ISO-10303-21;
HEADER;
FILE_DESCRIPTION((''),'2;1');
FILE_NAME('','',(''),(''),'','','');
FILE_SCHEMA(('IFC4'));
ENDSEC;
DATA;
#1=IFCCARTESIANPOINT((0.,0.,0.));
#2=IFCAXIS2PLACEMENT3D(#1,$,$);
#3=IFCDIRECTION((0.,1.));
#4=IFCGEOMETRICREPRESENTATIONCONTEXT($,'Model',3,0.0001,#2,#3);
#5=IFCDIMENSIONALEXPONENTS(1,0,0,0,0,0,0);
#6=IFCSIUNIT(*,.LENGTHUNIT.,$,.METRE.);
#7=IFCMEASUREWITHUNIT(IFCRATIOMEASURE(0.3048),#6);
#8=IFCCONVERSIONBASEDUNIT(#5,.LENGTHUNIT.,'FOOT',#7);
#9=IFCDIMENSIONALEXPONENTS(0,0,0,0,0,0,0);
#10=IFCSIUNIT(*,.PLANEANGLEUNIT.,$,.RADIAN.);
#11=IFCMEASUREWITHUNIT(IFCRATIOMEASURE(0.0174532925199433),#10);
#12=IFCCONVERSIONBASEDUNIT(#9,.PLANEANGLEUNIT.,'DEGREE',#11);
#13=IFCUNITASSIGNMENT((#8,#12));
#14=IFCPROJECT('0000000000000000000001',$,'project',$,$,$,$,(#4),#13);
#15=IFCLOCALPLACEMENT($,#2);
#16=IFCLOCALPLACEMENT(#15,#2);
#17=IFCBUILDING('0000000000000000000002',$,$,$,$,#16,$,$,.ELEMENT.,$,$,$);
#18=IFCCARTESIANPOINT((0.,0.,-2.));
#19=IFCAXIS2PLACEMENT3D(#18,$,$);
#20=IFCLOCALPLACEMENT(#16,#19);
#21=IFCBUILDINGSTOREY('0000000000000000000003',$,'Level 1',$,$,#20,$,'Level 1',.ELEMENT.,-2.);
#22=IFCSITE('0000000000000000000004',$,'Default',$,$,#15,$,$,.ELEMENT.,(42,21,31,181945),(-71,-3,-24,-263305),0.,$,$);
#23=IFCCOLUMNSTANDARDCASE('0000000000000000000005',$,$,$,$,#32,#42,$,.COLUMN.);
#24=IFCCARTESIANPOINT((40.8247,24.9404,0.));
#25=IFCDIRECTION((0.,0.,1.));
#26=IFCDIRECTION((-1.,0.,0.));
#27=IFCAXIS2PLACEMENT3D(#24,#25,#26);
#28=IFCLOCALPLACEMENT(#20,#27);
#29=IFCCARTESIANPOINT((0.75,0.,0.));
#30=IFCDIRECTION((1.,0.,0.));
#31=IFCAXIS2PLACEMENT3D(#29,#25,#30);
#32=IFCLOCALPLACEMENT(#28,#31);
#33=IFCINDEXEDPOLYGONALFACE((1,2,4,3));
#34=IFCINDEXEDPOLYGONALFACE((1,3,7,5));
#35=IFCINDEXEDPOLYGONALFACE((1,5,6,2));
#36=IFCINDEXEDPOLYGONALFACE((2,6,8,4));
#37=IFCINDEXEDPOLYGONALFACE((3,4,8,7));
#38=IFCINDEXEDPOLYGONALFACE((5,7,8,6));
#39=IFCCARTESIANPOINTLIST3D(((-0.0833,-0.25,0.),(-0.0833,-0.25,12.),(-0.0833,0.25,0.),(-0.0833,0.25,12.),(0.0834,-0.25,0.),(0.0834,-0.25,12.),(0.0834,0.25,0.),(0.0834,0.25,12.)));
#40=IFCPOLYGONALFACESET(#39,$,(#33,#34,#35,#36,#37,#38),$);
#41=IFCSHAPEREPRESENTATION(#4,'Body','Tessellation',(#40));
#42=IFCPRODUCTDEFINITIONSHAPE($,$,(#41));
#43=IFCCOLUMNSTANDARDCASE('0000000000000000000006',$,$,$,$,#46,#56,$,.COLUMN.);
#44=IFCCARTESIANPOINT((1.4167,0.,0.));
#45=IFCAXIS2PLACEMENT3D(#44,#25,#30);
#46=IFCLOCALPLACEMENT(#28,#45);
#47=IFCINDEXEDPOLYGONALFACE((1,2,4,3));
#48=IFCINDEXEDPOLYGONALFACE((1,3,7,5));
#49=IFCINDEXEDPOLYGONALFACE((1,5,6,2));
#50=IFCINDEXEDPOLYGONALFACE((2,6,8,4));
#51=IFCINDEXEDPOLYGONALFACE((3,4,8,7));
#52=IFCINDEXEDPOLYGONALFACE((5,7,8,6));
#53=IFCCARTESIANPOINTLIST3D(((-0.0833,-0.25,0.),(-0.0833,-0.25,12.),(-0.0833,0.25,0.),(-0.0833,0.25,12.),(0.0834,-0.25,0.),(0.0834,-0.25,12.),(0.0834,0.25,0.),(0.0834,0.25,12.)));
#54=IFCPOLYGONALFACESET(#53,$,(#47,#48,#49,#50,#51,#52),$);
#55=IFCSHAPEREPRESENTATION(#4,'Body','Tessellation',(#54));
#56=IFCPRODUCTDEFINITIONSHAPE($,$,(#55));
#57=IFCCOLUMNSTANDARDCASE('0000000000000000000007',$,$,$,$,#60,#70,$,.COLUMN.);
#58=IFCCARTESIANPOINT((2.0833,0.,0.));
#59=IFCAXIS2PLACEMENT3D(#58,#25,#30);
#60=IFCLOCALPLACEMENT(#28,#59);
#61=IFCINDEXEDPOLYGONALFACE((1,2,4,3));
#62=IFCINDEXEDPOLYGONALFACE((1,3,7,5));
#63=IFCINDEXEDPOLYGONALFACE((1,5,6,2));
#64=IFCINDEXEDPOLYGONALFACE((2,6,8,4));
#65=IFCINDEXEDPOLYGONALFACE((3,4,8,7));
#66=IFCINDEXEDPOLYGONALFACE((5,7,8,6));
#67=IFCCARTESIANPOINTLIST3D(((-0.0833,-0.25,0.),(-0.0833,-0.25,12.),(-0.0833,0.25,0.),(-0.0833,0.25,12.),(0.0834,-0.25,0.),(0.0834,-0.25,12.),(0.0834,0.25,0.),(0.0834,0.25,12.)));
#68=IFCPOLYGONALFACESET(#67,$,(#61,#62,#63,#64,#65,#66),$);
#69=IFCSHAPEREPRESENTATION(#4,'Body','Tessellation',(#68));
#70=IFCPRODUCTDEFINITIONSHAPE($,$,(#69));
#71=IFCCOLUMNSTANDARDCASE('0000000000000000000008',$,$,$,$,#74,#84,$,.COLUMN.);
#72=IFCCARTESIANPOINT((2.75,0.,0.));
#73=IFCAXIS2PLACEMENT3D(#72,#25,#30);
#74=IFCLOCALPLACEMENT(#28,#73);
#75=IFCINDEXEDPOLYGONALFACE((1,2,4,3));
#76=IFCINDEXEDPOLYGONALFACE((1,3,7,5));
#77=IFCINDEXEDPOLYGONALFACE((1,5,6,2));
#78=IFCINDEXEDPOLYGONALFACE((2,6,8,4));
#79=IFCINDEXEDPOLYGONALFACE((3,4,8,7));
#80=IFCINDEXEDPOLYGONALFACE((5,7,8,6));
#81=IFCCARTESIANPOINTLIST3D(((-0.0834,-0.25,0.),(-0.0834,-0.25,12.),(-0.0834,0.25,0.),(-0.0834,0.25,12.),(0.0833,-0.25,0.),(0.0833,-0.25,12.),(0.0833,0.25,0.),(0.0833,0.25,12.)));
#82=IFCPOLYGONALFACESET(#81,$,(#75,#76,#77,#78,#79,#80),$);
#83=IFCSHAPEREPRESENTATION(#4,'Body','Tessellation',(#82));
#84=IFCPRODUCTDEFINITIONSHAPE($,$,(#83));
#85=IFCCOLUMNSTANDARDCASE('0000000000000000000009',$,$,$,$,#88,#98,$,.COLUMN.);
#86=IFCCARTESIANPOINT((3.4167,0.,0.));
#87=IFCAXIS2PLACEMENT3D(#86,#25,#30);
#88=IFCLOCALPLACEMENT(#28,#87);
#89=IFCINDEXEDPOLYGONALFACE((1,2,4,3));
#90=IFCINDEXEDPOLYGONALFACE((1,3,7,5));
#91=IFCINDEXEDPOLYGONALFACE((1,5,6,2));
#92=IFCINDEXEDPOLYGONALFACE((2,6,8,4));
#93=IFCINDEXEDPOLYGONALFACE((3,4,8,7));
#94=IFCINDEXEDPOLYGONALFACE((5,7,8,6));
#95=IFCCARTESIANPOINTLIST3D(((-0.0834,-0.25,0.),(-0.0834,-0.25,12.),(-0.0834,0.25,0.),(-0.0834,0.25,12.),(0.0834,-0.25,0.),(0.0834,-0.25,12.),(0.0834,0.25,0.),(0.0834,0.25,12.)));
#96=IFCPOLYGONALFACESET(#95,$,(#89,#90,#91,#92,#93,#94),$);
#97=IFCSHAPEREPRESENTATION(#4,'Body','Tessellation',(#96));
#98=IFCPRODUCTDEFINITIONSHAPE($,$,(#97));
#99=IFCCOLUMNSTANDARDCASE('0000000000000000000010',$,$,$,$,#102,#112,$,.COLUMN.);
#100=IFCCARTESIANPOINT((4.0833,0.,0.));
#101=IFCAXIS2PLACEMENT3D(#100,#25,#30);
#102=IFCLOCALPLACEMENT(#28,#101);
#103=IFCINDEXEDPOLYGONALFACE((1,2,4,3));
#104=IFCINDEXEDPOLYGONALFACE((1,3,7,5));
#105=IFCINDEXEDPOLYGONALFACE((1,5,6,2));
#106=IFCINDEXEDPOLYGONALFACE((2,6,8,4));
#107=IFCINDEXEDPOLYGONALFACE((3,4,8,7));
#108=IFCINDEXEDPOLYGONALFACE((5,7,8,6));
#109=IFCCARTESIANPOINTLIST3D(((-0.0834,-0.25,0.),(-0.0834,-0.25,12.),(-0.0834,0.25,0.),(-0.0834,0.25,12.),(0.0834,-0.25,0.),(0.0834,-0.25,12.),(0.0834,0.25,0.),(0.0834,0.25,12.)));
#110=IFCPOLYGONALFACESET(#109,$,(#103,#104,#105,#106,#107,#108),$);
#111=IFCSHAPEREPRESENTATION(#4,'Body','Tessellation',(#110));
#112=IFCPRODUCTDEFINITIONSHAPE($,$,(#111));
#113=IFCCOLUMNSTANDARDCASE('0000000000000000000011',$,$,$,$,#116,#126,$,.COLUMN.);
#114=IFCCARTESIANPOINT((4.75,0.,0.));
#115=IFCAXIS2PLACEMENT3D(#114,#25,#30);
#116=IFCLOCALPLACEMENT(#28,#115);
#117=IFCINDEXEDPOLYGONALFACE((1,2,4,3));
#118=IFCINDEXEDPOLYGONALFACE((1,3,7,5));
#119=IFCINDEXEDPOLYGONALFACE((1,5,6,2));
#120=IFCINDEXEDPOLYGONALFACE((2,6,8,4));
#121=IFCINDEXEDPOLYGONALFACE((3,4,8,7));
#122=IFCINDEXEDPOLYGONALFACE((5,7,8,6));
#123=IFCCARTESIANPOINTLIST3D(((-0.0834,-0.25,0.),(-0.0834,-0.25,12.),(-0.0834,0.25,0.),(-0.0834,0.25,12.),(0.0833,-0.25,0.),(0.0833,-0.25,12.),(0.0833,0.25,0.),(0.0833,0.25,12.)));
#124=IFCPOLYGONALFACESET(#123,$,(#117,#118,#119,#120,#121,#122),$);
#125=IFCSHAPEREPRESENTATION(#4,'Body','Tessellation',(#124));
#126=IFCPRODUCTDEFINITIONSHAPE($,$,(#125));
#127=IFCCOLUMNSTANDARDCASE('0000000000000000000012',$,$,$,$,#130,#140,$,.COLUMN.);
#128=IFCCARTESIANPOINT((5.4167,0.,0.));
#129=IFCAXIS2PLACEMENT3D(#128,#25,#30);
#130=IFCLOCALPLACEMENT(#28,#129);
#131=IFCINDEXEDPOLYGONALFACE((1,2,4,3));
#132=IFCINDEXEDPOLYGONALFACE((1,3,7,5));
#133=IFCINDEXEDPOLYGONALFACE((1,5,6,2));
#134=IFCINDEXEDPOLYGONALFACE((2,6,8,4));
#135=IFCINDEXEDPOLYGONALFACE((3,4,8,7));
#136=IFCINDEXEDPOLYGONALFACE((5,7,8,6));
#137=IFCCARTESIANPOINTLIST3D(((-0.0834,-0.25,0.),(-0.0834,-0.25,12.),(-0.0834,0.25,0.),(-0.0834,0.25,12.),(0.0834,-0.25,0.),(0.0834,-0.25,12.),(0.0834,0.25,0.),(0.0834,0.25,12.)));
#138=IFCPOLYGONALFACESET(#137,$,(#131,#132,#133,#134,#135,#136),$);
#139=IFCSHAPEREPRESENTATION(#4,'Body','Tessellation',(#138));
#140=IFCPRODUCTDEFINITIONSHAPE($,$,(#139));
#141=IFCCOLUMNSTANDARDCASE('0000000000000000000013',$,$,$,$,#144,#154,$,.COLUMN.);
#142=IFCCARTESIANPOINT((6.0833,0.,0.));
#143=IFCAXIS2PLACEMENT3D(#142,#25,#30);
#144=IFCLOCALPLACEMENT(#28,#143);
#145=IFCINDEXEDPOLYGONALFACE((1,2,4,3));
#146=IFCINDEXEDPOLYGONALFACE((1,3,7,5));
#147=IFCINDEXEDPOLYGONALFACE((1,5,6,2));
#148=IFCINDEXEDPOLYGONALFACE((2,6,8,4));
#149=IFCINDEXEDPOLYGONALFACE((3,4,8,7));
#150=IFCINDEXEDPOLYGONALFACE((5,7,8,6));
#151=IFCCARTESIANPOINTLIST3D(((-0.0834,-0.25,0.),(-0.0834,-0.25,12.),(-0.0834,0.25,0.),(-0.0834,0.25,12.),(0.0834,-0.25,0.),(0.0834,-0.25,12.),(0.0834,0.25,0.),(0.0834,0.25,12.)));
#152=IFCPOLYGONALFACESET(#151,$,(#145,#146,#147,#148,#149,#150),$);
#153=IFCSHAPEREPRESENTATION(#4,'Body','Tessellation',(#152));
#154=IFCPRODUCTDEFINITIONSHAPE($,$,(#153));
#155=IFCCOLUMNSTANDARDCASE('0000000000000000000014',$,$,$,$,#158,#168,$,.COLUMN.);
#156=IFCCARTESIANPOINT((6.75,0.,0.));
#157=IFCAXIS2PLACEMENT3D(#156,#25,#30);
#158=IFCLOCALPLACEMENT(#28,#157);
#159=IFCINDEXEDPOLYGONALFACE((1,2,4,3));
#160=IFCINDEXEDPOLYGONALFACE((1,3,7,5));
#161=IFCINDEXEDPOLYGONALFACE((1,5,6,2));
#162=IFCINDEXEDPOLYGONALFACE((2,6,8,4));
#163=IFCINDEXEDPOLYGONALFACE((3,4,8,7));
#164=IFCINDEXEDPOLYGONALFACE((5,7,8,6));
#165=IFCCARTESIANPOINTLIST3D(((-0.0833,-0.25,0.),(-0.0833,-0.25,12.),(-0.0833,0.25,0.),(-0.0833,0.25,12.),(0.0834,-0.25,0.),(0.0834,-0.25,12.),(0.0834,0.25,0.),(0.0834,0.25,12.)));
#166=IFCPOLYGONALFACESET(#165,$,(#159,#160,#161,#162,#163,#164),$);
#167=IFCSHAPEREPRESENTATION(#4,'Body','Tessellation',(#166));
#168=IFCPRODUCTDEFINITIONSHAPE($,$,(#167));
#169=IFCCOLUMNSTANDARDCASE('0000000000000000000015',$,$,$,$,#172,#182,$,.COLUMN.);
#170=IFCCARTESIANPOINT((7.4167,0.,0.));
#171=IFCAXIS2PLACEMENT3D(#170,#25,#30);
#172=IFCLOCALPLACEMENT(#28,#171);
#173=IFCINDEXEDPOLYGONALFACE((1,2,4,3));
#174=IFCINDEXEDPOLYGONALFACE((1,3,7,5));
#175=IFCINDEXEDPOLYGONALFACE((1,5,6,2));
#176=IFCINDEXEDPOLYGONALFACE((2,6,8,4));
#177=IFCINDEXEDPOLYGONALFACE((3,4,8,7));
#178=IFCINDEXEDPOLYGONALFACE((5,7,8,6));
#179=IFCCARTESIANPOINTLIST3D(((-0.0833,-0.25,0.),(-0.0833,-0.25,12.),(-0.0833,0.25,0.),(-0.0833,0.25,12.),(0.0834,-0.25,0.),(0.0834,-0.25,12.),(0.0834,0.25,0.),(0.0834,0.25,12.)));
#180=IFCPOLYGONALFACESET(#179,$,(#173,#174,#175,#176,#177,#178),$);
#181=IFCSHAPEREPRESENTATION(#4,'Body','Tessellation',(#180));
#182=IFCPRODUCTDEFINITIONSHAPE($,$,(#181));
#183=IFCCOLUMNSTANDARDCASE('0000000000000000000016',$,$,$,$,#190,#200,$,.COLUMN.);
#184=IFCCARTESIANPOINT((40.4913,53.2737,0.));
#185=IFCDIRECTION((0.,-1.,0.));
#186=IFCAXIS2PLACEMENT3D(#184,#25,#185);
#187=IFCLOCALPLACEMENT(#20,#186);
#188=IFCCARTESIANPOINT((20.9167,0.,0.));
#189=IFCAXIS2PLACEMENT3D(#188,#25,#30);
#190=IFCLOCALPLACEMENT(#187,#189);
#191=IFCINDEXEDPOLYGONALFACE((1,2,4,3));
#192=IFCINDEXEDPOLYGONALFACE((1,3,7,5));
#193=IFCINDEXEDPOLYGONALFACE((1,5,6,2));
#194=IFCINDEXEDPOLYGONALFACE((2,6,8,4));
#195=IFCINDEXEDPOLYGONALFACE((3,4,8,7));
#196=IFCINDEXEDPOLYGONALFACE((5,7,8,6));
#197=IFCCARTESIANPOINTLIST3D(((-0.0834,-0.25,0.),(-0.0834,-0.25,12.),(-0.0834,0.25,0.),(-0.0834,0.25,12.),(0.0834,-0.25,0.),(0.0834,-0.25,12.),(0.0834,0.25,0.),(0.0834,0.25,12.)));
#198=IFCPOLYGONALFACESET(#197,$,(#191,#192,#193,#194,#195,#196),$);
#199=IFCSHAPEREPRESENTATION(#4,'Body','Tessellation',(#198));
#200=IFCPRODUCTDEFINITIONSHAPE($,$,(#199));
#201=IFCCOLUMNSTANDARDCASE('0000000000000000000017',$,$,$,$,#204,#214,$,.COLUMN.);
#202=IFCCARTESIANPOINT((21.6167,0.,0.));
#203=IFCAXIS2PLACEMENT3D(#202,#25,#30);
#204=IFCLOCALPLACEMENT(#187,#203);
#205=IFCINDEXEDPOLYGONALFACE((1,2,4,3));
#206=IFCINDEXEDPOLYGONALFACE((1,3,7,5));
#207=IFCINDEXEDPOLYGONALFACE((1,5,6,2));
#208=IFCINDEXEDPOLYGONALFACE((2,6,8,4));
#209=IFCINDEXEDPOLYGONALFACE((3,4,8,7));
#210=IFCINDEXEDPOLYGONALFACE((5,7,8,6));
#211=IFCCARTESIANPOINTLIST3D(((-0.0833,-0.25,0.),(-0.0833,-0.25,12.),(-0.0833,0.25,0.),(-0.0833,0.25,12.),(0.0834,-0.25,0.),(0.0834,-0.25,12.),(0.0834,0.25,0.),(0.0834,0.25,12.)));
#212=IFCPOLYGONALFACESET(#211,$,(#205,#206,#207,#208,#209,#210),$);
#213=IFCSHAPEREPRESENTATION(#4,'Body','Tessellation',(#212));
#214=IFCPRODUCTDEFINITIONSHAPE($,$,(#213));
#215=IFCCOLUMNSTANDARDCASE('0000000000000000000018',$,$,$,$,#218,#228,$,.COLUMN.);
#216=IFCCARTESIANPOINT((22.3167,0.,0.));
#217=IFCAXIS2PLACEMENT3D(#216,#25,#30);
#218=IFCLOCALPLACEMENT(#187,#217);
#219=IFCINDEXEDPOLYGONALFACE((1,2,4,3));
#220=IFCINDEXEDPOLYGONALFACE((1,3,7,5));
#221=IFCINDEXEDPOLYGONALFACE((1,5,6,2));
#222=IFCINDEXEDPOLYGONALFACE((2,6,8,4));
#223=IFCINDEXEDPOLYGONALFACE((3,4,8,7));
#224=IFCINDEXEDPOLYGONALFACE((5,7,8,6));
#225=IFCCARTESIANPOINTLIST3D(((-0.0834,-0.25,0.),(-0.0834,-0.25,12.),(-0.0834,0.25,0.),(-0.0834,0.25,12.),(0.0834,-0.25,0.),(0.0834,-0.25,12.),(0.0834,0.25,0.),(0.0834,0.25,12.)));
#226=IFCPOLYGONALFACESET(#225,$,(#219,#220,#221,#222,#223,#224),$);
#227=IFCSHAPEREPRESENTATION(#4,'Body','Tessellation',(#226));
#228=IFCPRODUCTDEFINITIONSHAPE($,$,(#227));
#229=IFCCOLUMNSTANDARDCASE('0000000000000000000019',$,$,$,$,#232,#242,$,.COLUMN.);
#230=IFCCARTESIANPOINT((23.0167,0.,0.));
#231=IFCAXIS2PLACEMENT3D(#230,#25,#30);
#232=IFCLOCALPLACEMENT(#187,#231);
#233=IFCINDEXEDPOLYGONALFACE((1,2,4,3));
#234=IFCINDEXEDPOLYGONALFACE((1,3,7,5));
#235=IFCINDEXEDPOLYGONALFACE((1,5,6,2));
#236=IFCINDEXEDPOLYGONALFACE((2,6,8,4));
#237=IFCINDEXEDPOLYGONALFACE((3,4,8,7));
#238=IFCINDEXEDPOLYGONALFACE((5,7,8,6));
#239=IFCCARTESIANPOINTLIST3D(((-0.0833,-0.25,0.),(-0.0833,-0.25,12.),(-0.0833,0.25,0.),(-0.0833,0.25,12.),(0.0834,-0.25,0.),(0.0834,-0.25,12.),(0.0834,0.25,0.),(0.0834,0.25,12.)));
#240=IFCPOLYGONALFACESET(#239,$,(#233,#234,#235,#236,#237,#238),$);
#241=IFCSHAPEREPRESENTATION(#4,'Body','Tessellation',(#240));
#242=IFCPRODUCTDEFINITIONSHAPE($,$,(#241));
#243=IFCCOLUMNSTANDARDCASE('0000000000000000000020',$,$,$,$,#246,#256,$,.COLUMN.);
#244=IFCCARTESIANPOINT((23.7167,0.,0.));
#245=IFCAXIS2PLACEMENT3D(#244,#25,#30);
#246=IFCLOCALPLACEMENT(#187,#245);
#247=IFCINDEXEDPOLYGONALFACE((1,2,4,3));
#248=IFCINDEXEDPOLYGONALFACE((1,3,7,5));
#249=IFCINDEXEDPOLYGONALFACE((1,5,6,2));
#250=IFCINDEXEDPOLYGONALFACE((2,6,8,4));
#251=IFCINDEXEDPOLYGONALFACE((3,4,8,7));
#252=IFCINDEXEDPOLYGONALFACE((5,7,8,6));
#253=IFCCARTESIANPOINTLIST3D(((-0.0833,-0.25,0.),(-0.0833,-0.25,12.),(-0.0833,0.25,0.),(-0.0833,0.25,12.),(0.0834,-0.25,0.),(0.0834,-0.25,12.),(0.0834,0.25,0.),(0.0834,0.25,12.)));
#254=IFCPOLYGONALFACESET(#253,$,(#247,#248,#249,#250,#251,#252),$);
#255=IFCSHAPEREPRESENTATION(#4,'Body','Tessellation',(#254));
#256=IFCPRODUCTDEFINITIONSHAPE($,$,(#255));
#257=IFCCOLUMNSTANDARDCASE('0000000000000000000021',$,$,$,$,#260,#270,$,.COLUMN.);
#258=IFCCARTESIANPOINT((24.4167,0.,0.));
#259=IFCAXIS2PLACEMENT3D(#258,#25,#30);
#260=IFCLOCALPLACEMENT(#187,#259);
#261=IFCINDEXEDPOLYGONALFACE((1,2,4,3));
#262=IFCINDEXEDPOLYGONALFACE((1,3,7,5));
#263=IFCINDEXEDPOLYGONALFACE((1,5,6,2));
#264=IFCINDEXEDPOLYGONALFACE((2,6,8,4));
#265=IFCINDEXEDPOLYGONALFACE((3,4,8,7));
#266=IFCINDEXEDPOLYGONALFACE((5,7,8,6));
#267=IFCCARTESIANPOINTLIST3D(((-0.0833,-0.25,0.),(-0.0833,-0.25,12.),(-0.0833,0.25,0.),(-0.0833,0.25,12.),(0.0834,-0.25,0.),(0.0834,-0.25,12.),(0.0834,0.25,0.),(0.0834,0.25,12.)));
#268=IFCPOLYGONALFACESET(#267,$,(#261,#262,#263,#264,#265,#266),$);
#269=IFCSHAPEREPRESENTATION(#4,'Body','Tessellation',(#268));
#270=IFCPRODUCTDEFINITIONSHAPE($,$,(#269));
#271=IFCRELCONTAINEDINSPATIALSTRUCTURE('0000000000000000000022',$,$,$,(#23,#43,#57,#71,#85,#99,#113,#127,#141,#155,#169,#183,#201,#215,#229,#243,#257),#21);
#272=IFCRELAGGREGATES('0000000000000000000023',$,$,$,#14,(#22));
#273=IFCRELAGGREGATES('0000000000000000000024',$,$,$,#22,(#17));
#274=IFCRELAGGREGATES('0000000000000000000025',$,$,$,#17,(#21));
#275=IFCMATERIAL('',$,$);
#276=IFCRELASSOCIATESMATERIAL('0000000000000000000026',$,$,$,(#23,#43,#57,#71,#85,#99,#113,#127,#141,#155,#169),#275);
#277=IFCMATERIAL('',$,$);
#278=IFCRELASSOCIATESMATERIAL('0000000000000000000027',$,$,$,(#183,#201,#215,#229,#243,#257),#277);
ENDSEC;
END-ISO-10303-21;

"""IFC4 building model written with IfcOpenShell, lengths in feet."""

from ifc_helpers import new_model, entity, si_unit, converted_unit, direction, frame, origin, place, context, project, spatial, rectangle, extrude, material, element, save


model = new_model("IFC4")

# Units and contexts
model_context = context("Model", 3, precision=0.0001, world=origin(), true_north=direction((0.0, 1.0)))
ifc_project = project(units=[converted_unit("LENGTHUNIT", "FOOT", entity("IfcRatioMeasure", 0.3048), si_unit("LENGTHUNIT", "METRE"), dimensions=[1, 0, 0, 0, 0, 0, 0]), converted_unit("PLANEANGLEUNIT", "DEGREE", entity("IfcRatioMeasure", 0.0174532925199433), si_unit("PLANEANGLEUNIT", "RADIAN"), dimensions=[0, 0, 0, 0, 0, 0, 0])], contexts=[model_context])

# Site, building, storey
site_placement = place(None, origin())
site = spatial("IfcSite", under=ifc_project, at=site_placement, Name="Default", CompositionType="ELEMENT", RefLatitude=(42, 21, 31, 181945), RefLongitude=(-71, -3, -24, -263305), RefElevation=0.0)
building_placement = place(site_placement, origin())
building = spatial("IfcBuilding", under=site, at=building_placement, CompositionType="ELEMENT")
storey_placement = place(building_placement, frame((0.0, 0.0, -2.0)))
storey = spatial("IfcBuildingStorey", under=building, at=storey_placement, Name="Level 1", LongName="Level 1", CompositionType="ELEMENT", Elevation=-2.0)

# Columns
ifc_material_1 = material(Name="")
wall_placement = place(storey_placement, frame((40.8247, 24.9404, 0.0), z_axis=(0.0, 0.0, 1.0), x_axis=(-1.0, 0.0, 0.0)))
for number, where, z_axis, x_axis in (
    (1, (0.75, 0.0, 0.0), (0.0, 0.0, 1.0), (1.0, 0.0, 0.0)),
    (2, (1.4167, 0.0, 0.0), (0.0, 0.0, 1.0), (1.0, 0.0, 0.0)),
    (3, (2.0833, 0.0, 0.0), (0.0, 0.0, 1.0), (1.0, 0.0, 0.0)),
    (4, (2.75, 0.0, 0.0), (0.0, 0.0, 1.0), (1.0, 0.0, 0.0)),
    (5, (3.4167, 0.0, 0.0), (0.0, 0.0, 1.0), (1.0, 0.0, 0.0)),
    (6, (4.0833, 0.0, 0.0), (0.0, 0.0, 1.0), (1.0, 0.0, 0.0)),
    (7, (4.75, 0.0, 0.0), (0.0, 0.0, 1.0), (1.0, 0.0, 0.0)),
    (8, (5.4167, 0.0, 0.0), (0.0, 0.0, 1.0), (1.0, 0.0, 0.0)),
    (9, (6.0833, 0.0, 0.0), (0.0, 0.0, 1.0), (1.0, 0.0, 0.0)),
    (10, (6.75, 0.0, 0.0), (0.0, 0.0, 1.0), (1.0, 0.0, 0.0)),
    (11, (7.4167, 0.0, 0.0), (0.0, 0.0, 1.0), (1.0, 0.0, 0.0)),
):
    element("IfcColumnStandardCase", number, at=place(wall_placement, frame(where, z_axis=z_axis, x_axis=x_axis)), inside=storey, material=ifc_material_1, PredefinedType="COLUMN", context=model_context, shape_type="SweptSolid", body=[
        extrude(rectangle(XDim=0.1667, YDim=0.5), origin(), (0.0, 0.0, 1.0), 12.0),
    ])
ifc_material_2 = material(Name="")
placement = place(storey_placement, frame((40.4913, 53.2737, 0.0), z_axis=(0.0, 0.0, 1.0), x_axis=(0.0, -1.0, 0.0)))
for number, where, z_axis, x_axis in (
    (12, (20.9167, 0.0, 0.0), (0.0, 0.0, 1.0), (1.0, 0.0, 0.0)),
    (13, (21.6167, 0.0, 0.0), (0.0, 0.0, 1.0), (1.0, 0.0, 0.0)),
    (14, (22.3167, 0.0, 0.0), (0.0, 0.0, 1.0), (1.0, 0.0, 0.0)),
    (15, (23.0167, 0.0, 0.0), (0.0, 0.0, 1.0), (1.0, 0.0, 0.0)),
    (16, (23.7167, 0.0, 0.0), (0.0, 0.0, 1.0), (1.0, 0.0, 0.0)),
    (17, (24.4167, 0.0, 0.0), (0.0, 0.0, 1.0), (1.0, 0.0, 0.0)),
):
    element("IfcColumnStandardCase", number, at=place(placement, frame(where, z_axis=z_axis, x_axis=x_axis)), inside=storey, material=ifc_material_2, PredefinedType="COLUMN", context=model_context, shape_type="SweptSolid", body=[
        extrude(rectangle(XDim=0.1667, YDim=0.5), origin(), (0.0, 0.0, 1.0), 12.0),
    ])

save(model, "model.ifc")
